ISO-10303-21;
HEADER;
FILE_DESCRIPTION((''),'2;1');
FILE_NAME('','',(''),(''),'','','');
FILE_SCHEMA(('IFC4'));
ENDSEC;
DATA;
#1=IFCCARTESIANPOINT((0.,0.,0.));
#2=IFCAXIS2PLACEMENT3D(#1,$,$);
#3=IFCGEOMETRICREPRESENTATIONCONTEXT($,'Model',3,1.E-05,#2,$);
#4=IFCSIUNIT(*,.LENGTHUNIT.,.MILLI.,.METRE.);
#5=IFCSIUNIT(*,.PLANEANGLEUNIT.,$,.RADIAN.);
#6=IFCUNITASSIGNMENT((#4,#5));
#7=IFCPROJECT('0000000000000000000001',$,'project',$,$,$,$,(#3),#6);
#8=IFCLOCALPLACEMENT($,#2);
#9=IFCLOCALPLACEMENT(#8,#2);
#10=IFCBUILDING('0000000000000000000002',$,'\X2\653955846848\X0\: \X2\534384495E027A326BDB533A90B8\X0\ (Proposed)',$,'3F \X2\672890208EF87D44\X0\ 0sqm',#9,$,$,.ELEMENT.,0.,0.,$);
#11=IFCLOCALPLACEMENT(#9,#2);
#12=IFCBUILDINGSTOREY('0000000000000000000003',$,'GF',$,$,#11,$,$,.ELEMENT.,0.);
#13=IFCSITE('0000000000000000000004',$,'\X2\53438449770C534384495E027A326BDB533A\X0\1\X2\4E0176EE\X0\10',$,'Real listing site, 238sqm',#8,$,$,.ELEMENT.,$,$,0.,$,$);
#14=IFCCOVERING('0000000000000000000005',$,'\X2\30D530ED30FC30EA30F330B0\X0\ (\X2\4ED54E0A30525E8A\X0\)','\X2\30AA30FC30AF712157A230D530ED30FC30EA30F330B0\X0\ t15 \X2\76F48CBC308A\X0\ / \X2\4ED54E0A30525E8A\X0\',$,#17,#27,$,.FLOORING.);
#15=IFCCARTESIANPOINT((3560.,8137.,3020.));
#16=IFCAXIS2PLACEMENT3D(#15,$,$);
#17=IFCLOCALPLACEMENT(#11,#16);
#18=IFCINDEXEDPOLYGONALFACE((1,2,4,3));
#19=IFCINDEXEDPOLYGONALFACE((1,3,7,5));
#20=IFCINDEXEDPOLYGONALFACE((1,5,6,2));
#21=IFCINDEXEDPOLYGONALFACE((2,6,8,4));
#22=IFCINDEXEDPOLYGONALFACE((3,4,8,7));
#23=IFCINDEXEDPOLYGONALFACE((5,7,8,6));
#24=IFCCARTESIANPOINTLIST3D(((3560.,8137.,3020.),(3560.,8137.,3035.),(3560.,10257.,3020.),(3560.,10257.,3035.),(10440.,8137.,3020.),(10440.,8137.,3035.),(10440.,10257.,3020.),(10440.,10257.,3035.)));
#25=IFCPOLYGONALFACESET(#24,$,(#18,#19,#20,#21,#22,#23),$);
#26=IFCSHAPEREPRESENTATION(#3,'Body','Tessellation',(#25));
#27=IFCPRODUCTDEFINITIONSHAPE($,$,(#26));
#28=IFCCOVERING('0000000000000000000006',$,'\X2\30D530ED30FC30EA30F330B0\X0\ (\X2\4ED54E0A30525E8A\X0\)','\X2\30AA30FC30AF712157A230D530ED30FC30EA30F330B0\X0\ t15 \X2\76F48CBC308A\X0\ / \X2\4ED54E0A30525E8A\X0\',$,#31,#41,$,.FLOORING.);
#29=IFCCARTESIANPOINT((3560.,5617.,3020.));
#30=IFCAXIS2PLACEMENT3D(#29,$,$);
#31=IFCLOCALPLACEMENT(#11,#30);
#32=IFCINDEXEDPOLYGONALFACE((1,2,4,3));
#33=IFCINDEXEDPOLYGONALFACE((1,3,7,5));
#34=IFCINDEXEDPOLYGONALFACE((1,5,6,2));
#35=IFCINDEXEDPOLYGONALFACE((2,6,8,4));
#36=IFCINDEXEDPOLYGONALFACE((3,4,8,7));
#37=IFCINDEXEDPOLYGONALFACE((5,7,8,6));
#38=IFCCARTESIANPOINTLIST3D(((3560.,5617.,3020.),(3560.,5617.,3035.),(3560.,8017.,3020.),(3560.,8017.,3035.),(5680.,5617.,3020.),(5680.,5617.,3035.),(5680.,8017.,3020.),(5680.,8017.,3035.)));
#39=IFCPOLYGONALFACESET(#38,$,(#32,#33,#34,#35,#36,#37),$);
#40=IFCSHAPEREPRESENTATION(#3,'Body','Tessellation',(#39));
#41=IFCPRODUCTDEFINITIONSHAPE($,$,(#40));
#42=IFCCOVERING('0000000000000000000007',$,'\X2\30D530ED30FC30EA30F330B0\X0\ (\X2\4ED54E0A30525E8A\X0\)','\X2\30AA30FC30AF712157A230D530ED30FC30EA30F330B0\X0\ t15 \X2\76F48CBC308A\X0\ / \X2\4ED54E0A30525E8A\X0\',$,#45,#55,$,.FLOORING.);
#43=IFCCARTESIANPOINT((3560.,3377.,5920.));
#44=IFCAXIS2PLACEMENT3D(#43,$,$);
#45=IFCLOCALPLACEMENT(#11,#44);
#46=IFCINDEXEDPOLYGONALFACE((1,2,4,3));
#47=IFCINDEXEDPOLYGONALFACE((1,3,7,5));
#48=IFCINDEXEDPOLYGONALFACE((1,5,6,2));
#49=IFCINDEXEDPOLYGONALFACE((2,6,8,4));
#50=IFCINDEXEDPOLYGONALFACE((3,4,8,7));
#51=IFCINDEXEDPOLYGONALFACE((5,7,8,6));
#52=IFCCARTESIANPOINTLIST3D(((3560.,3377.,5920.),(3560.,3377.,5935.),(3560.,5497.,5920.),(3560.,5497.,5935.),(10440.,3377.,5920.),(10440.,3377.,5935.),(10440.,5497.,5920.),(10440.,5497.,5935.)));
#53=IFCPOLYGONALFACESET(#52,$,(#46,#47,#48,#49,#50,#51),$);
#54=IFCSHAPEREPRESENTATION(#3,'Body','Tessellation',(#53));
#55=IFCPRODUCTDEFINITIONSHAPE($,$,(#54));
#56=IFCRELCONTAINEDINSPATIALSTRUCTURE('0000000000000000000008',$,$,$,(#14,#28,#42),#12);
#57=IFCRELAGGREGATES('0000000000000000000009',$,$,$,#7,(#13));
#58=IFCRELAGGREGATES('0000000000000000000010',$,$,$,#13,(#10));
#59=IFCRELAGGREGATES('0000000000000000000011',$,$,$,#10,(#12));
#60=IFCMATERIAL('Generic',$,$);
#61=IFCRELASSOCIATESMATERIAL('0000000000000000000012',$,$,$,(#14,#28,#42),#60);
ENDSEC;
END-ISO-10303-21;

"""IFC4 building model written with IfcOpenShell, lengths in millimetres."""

from ifc_helpers import new_model, si_unit, frame, frame_2d, origin, place, context, project, spatial, rectangle, extrude, material, element, save


model = new_model("IFC4")

# Units and contexts
model_context = context("Model", 3, precision=1e-05, world=origin())
ifc_project = project(units=[si_unit("LENGTHUNIT", "METRE", prefix="MILLI"), si_unit("PLANEANGLEUNIT", "RADIAN")], contexts=[model_context])

# Site, building, storey
site_placement = place(None, origin())
site = spatial("IfcSite", under=ifc_project, at=site_placement, Name="千葉県千葉市稲毛区1丁目10", ObjectType="Real listing site, 238sqm", CompositionType="ELEMENT", RefElevation=0.0)
building_placement = place(site_placement, origin())
building = spatial("IfcBuilding", under=site, at=building_placement, Name="改善案: 千葉市稲毛区邸 (Proposed)", ObjectType="3F 木造軸組 0sqm", CompositionType="ELEMENT", ElevationOfRefHeight=0.0, ElevationOfTerrain=0.0)
storey_placement = place(building_placement, origin())
storey = spatial("IfcBuildingStorey", under=building, at=storey_placement, Name="GF", CompositionType="ELEMENT", Elevation=0.0)

# Shared definitions
ifc_material_1 = material(Name="Generic")

# Coverings
covering_1_placement = place(storey_placement, frame((3560.0, 8137.0, 3020.0)))
element("IfcCovering", 1, at=covering_1_placement, inside=storey, material=ifc_material_1, Name="フローリング (仕上げ床)", Description="オーク無垢フローリング t15 直貼り / 仕上げ床", PredefinedType="FLOORING", context=model_context, shape_type="SweptSolid", body=[
    extrude(rectangle(XDim=6880.0, YDim=2120.0, at=frame_2d((3440.0, 1060.0))), frame((3560.0, 8137.0, 3020.0)), (0.0, 0.0, 1.0), 15.0),
])
covering_2_placement = place(storey_placement, frame((3560.0, 5617.0, 3020.0)))
element("IfcCovering", 2, at=covering_2_placement, inside=storey, material=ifc_material_1, Name="フローリング (仕上げ床)", Description="オーク無垢フローリング t15 直貼り / 仕上げ床", PredefinedType="FLOORING", context=model_context, shape_type="SweptSolid", body=[
    extrude(rectangle(XDim=2120.0, YDim=2400.0, at=frame_2d((1060.0, 1200.0))), frame((3560.0, 5617.0, 3020.0)), (0.0, 0.0, 1.0), 15.0),
])
covering_3_placement = place(storey_placement, frame((3560.0, 3377.0, 5920.0)))
element("IfcCovering", 3, at=covering_3_placement, inside=storey, material=ifc_material_1, Name="フローリング (仕上げ床)", Description="オーク無垢フローリング t15 直貼り / 仕上げ床", PredefinedType="FLOORING", context=model_context, shape_type="SweptSolid", body=[
    extrude(rectangle(XDim=6880.0, YDim=2120.0, at=frame_2d((3440.0, 1060.0))), frame((3560.0, 3377.0, 5920.0)), (0.0, 0.0, 1.0), 15.0),
])

save(model, "model.ifc")
